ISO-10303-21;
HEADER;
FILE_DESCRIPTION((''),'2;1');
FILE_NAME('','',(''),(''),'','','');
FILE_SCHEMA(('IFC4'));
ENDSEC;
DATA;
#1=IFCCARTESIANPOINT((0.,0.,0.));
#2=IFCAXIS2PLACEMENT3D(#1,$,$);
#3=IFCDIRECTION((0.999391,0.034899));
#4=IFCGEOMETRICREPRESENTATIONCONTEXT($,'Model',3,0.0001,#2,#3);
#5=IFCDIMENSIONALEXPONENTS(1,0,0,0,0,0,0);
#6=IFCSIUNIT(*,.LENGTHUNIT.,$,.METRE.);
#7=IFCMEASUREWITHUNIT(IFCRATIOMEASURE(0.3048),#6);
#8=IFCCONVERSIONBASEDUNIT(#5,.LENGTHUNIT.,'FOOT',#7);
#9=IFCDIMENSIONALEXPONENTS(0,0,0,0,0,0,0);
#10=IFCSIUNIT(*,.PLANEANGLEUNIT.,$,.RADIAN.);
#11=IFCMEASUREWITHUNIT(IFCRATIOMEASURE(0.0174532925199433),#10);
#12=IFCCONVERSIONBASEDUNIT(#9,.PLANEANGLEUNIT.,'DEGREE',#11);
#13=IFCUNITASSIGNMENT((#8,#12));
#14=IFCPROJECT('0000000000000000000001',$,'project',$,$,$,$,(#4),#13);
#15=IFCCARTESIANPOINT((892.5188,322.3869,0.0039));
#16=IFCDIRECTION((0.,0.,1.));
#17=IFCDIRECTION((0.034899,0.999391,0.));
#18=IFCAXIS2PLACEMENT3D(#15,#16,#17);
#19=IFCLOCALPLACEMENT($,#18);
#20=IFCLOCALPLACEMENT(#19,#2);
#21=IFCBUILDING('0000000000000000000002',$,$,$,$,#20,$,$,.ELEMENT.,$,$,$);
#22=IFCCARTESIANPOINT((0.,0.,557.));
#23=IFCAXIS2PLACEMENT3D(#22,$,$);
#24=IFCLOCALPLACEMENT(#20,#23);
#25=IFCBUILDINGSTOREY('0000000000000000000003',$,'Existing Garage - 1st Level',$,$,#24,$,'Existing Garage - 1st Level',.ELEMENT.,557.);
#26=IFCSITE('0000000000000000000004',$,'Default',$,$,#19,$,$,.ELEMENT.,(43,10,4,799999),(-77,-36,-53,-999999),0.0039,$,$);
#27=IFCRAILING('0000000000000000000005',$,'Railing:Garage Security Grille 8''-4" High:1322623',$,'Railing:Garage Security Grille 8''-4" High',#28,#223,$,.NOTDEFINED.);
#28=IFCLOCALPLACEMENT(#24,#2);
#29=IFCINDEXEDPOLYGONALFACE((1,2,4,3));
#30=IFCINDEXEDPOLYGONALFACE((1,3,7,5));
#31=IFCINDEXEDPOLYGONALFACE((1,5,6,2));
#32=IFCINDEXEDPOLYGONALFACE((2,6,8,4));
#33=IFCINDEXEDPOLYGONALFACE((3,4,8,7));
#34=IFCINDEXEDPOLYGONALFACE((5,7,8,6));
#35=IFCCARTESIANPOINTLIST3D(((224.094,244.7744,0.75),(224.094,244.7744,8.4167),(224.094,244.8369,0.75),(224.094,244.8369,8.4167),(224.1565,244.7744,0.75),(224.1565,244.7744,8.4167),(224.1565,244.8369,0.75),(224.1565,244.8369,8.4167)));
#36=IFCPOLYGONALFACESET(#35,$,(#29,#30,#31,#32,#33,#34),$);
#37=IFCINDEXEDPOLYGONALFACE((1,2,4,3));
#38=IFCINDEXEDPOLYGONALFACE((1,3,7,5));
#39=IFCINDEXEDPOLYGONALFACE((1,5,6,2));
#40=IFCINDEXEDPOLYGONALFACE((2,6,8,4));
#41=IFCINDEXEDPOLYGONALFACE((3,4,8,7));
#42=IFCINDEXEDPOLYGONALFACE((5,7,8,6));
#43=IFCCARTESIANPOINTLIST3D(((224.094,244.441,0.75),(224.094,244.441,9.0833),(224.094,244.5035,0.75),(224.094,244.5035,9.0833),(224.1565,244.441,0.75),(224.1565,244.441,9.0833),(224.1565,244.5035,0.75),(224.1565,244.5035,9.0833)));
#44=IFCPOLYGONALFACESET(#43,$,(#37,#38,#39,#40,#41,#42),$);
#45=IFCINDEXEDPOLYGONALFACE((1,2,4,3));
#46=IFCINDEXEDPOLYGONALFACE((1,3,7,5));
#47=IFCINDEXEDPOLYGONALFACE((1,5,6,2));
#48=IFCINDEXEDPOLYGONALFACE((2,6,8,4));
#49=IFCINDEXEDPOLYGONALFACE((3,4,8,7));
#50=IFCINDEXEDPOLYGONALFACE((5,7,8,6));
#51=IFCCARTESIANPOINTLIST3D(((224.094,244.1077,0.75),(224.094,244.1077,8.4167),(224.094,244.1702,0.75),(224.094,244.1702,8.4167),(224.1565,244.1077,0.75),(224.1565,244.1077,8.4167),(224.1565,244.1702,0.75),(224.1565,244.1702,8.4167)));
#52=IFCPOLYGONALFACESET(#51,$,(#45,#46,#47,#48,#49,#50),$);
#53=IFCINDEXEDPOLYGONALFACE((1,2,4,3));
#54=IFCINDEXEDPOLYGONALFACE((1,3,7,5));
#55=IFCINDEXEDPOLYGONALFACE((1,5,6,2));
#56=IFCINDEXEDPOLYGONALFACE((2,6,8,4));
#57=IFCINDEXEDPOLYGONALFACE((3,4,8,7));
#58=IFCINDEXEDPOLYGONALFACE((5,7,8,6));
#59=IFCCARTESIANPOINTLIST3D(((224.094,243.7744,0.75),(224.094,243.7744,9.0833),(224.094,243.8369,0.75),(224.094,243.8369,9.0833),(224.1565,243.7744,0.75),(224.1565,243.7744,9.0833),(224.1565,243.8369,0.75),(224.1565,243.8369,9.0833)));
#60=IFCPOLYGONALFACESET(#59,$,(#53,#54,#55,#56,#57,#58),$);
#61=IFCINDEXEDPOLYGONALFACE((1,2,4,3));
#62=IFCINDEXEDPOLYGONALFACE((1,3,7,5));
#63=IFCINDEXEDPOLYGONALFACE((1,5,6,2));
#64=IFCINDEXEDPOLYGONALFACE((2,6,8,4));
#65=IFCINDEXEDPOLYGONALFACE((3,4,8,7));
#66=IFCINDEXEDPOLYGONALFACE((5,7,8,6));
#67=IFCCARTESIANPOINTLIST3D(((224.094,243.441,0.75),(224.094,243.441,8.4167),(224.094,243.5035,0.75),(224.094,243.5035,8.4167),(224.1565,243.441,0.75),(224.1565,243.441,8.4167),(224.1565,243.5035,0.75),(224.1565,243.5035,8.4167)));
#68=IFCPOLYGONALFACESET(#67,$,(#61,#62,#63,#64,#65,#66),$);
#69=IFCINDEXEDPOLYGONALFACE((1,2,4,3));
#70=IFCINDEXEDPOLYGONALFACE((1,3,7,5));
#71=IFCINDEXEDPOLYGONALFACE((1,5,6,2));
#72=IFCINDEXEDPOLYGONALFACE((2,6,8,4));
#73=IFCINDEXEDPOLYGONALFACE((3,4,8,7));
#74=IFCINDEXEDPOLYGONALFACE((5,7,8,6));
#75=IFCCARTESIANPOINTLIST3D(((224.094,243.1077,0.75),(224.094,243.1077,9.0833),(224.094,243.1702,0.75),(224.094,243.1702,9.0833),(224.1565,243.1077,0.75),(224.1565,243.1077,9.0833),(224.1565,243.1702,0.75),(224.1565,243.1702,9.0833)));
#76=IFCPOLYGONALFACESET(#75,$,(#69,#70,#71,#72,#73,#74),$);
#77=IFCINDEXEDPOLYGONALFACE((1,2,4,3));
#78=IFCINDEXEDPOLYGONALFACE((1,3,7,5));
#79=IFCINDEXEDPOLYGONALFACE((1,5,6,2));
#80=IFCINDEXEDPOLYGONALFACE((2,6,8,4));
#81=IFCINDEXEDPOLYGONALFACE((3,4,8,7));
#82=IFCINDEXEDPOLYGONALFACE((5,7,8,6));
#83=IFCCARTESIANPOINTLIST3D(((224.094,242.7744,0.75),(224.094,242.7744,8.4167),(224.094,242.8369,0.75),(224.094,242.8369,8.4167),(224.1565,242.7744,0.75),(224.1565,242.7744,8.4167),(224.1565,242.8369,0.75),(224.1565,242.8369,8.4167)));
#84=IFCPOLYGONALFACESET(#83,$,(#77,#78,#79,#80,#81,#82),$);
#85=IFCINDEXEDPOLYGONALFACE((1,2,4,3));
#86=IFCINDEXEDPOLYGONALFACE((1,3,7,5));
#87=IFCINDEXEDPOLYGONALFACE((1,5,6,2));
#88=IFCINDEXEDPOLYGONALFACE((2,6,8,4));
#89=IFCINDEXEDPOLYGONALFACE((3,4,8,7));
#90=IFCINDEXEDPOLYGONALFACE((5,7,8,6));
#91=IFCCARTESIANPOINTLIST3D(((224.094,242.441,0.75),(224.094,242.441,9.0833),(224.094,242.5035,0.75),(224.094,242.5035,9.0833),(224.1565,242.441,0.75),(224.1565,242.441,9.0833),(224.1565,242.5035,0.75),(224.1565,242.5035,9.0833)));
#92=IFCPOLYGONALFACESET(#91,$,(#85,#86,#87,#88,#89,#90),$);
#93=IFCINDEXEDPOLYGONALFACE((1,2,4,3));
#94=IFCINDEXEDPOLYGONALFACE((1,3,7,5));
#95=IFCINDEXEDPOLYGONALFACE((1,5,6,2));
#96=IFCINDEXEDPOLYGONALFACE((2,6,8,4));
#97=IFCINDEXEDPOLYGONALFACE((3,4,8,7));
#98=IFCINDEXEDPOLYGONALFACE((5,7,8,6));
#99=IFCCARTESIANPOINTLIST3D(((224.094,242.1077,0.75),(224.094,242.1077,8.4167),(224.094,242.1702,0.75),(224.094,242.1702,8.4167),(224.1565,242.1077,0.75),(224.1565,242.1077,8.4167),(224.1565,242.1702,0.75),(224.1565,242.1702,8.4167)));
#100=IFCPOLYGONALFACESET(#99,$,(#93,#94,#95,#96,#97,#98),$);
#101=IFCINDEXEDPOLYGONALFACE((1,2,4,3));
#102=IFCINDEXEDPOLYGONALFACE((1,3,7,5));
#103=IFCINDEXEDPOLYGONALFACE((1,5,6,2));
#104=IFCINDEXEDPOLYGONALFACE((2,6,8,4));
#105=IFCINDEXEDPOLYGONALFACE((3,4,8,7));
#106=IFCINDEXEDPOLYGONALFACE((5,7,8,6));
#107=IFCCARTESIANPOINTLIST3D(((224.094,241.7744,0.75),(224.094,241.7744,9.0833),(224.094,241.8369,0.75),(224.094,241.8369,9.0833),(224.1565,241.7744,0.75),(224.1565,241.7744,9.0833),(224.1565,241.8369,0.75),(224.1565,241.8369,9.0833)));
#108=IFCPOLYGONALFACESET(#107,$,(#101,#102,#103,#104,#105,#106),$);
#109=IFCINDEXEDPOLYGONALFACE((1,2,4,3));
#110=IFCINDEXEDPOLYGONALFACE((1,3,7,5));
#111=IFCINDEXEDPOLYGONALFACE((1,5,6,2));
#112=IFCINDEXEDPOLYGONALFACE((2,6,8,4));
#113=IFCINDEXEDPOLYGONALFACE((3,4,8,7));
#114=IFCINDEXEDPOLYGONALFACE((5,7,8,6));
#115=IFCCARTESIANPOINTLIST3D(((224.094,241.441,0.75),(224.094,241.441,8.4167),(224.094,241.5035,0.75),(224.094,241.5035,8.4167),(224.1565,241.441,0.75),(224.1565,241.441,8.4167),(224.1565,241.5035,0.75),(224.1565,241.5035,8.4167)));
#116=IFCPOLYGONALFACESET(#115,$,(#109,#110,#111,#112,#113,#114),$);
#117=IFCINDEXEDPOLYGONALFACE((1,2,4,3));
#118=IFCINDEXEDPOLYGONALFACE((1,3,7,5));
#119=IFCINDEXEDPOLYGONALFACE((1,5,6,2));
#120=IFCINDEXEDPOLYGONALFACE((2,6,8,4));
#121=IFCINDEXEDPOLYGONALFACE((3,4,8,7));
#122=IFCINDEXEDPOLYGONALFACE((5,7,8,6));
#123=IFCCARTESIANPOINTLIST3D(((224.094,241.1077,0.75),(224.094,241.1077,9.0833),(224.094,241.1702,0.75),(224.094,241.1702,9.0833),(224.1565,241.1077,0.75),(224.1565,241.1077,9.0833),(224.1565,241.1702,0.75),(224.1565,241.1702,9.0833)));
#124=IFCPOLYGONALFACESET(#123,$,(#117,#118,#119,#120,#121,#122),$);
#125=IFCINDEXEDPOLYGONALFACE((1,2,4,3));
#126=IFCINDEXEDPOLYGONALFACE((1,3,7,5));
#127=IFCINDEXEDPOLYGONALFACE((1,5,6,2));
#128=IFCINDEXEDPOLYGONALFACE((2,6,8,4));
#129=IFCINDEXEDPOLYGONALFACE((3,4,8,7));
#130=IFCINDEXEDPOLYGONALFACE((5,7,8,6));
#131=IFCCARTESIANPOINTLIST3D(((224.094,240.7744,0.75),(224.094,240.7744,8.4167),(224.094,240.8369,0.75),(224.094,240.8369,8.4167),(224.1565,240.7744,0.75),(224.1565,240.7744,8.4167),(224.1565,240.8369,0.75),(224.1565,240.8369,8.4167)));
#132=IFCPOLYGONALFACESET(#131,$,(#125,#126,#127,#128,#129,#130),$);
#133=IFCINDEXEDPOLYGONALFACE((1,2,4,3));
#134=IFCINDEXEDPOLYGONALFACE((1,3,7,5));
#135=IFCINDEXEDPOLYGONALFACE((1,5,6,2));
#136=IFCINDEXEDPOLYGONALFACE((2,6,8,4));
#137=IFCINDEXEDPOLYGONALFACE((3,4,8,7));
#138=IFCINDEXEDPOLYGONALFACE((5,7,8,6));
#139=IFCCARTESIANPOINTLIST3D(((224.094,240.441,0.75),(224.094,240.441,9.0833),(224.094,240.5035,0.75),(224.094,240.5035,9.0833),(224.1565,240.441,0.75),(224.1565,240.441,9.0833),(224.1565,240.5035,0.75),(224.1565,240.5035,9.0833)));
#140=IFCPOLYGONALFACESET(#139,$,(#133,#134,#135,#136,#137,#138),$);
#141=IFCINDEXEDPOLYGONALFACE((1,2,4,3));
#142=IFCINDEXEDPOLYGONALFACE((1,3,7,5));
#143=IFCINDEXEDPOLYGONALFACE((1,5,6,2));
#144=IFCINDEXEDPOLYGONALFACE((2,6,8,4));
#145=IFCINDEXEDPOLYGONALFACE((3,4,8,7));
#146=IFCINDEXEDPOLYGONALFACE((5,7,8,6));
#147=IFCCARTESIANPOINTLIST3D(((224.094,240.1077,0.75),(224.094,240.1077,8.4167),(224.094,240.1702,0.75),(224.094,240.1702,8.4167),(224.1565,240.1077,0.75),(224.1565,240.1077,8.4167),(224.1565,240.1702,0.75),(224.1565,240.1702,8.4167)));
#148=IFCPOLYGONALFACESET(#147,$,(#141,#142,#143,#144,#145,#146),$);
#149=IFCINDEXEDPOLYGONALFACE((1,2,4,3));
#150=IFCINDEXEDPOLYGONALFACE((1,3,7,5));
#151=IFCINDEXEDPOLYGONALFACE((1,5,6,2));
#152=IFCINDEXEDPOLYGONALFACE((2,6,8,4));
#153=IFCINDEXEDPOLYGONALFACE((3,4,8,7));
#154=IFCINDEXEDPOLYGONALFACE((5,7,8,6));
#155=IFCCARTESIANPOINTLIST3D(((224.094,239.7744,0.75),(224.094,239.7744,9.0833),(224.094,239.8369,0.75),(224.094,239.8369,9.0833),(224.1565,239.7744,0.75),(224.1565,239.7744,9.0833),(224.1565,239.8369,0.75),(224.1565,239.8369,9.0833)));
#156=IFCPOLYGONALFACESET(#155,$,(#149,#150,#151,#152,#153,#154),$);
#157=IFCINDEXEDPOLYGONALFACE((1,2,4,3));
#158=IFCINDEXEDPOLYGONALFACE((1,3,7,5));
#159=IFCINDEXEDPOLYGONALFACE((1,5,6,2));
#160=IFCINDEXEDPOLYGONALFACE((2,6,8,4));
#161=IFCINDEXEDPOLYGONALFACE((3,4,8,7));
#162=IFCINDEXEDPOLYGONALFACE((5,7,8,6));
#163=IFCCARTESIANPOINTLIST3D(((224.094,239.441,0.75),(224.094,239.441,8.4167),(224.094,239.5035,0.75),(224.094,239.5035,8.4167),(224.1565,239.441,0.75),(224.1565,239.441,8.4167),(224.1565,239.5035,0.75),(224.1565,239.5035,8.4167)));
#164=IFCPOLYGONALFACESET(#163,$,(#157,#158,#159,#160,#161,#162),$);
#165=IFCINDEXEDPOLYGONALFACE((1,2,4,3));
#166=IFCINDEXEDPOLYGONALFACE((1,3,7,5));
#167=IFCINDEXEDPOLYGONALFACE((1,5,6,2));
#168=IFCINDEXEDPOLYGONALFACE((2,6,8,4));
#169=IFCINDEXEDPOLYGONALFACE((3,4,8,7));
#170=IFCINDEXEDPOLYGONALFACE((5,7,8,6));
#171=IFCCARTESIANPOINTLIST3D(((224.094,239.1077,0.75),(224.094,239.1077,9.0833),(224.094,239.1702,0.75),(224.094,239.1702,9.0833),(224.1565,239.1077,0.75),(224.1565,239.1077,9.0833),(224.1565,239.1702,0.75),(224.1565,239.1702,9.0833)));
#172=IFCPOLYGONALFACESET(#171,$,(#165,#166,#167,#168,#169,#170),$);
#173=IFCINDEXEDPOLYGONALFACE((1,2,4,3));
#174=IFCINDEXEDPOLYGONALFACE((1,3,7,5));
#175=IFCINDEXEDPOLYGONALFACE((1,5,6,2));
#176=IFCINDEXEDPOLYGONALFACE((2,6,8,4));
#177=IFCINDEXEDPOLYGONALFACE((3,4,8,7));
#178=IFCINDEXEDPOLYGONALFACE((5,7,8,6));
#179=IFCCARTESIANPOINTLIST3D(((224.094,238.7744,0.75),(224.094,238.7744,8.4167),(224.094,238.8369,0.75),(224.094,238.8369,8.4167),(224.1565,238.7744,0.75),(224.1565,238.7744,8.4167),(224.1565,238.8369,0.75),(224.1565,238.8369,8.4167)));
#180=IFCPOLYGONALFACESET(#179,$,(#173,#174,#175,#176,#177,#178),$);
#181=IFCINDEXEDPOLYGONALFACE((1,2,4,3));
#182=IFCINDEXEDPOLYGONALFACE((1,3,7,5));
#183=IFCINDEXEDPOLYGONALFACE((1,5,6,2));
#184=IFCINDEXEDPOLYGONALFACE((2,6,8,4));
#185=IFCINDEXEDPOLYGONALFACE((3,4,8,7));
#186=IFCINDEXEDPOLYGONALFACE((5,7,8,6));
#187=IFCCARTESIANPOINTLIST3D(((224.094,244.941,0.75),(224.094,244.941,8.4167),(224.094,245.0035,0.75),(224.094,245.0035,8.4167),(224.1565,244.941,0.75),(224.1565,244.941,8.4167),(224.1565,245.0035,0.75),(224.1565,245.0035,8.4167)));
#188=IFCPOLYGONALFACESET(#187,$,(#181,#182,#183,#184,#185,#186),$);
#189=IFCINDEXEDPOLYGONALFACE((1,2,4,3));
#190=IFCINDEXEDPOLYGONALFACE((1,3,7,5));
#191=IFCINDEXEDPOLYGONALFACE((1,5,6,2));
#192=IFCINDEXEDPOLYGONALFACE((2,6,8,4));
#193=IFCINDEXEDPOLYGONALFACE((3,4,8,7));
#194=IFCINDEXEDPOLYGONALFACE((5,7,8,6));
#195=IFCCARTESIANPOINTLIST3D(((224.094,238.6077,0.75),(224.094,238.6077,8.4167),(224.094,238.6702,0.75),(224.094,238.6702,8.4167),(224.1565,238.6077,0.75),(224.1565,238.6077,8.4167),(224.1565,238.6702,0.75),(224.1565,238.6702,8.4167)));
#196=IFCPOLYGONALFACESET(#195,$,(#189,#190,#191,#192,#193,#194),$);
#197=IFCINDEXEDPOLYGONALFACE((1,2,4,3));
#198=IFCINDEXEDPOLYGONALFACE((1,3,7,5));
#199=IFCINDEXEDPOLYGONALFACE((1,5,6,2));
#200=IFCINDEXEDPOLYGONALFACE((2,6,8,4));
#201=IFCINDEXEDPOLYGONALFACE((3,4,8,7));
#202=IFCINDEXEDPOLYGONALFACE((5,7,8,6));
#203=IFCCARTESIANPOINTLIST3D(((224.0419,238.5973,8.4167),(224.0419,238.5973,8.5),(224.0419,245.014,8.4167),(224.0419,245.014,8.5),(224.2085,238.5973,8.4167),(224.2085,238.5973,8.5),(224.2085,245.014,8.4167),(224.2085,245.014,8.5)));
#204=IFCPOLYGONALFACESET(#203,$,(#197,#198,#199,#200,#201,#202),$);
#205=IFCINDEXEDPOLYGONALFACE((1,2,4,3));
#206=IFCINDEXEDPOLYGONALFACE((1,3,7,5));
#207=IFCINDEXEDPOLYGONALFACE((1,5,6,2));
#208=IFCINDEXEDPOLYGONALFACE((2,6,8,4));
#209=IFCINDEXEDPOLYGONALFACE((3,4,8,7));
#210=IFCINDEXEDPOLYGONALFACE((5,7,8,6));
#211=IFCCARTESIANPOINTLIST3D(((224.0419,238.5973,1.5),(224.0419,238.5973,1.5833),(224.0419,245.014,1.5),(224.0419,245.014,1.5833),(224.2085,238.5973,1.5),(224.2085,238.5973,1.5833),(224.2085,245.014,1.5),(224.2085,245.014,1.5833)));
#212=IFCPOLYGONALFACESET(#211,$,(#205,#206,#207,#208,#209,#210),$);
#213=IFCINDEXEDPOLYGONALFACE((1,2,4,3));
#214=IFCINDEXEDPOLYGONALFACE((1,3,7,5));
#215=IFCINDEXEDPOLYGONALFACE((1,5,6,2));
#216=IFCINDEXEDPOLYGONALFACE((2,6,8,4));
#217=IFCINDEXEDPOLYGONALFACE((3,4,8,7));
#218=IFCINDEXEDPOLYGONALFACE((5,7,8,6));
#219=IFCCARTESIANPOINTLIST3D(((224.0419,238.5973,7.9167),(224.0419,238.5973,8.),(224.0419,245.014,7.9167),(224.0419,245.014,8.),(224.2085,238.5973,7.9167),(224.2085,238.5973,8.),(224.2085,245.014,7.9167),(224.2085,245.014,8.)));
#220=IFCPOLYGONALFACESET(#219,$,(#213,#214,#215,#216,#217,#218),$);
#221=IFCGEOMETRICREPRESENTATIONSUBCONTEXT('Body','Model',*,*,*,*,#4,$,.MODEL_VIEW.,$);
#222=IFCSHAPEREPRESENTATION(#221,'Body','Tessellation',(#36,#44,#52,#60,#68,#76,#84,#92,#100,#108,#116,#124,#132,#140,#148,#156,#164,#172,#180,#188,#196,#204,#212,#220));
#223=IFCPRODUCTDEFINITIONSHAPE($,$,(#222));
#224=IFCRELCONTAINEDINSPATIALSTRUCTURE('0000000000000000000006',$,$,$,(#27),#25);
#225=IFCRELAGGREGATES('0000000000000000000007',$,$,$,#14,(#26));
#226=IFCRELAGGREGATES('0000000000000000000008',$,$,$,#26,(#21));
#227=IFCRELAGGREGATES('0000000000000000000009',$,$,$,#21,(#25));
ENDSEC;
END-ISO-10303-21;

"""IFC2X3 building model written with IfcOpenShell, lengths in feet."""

from ifc_helpers import new_model, entity, si_unit, converted_unit, direction, frame, frame_2d, origin, origin_2d_with_axis, place, context, subcontext, project, spatial, rectangle, extrude, element, save


model = new_model("IFC2X3")

# Units and contexts
model_context = context("Model", 3, precision=0.0001, world=origin(), true_north=direction((0.999391, 0.034899)))
body_context = subcontext(model_context, "Body", "Model", "MODEL_VIEW")
ifc_project = project(units=[converted_unit("LENGTHUNIT", "FOOT", entity("IfcRatioMeasure", 0.3048), si_unit("LENGTHUNIT", "METRE"), dimensions=[1, 0, 0, 0, 0, 0, 0]), converted_unit("PLANEANGLEUNIT", "DEGREE", entity("IfcRatioMeasure", 0.0174532925199433), si_unit("PLANEANGLEUNIT", "RADIAN"), dimensions=[0, 0, 0, 0, 0, 0, 0])], contexts=[model_context])

# Site, building, storey
site_placement = place(None, frame((892.5188, 322.3869, 0.0039), z_axis=(0.0, 0.0, 1.0), x_axis=(0.034899, 0.999391, 0.0)))
site = spatial("IfcSite", under=ifc_project, at=site_placement, Name="Default", CompositionType="ELEMENT", RefLatitude=(43, 10, 4, 799999), RefLongitude=(-77, -36, -53, -999999), RefElevation=0.0039)
building_placement = place(site_placement, origin())
building = spatial("IfcBuilding", under=site, at=building_placement, CompositionType="ELEMENT")
storey_placement = place(building_placement, frame((0.0, 0.0, 557.0)))
storey = spatial("IfcBuildingStorey", under=building, at=storey_placement, Name="Existing Garage - 1st Level", LongName="Existing Garage - 1st Level", CompositionType="ELEMENT", Elevation=557.0)

# Railing
railing_1_placement = place(storey_placement, origin())
element("IfcRailing", 1, at=railing_1_placement, inside=storey, Name="Railing:Garage Security Grille 8'-4\" High:1322623", ObjectType="Railing:Garage Security Grille 8'-4\" High", PredefinedType="NOTDEFINED", context=body_context, shape_type="SweptSolid", body=[
    extrude(rectangle(XDim=0.0625, YDim=0.0625, at=origin_2d_with_axis()), frame((224.1252, 244.8056, 0.75), z_axis=(0.0, 0.0, 1.0), x_axis=(0.0, 1.0, 0.0)), (0.0, 0.0, 1.0), 7.6667),
    extrude(rectangle(XDim=0.0625, YDim=0.0625, at=origin_2d_with_axis()), frame((224.1252, 244.4723, 0.75), z_axis=(0.0, 0.0, 1.0), x_axis=(0.0, 1.0, 0.0)), (0.0, 0.0, 1.0), 8.3333),
    extrude(rectangle(XDim=0.0625, YDim=0.0625, at=origin_2d_with_axis()), frame((224.1252, 244.139, 0.75), z_axis=(0.0, 0.0, 1.0), x_axis=(0.0, 1.0, 0.0)), (0.0, 0.0, 1.0), 7.6667),
    extrude(rectangle(XDim=0.0625, YDim=0.0625, at=origin_2d_with_axis()), frame((224.1252, 243.8056, 0.75), z_axis=(0.0, 0.0, 1.0), x_axis=(0.0, 1.0, 0.0)), (0.0, 0.0, 1.0), 8.3333),
    extrude(rectangle(XDim=0.0625, YDim=0.0625, at=origin_2d_with_axis()), frame((224.1252, 243.4723, 0.75), z_axis=(0.0, 0.0, 1.0), x_axis=(0.0, 1.0, 0.0)), (0.0, 0.0, 1.0), 7.6667),
    extrude(rectangle(XDim=0.0625, YDim=0.0625, at=origin_2d_with_axis()), frame((224.1252, 243.139, 0.75), z_axis=(0.0, 0.0, 1.0), x_axis=(0.0, 1.0, 0.0)), (0.0, 0.0, 1.0), 8.3333),
    extrude(rectangle(XDim=0.0625, YDim=0.0625, at=origin_2d_with_axis()), frame((224.1252, 242.8056, 0.75), z_axis=(0.0, 0.0, 1.0), x_axis=(0.0, 1.0, 0.0)), (0.0, 0.0, 1.0), 7.6667),
    extrude(rectangle(XDim=0.0625, YDim=0.0625, at=origin_2d_with_axis()), frame((224.1252, 242.4723, 0.75), z_axis=(0.0, 0.0, 1.0), x_axis=(0.0, 1.0, 0.0)), (0.0, 0.0, 1.0), 8.3333),
    extrude(rectangle(XDim=0.0625, YDim=0.0625, at=origin_2d_with_axis()), frame((224.1252, 242.139, 0.75), z_axis=(0.0, 0.0, 1.0), x_axis=(0.0, 1.0, 0.0)), (0.0, 0.0, 1.0), 7.6667),
    extrude(rectangle(XDim=0.0625, YDim=0.0625, at=origin_2d_with_axis()), frame((224.1252, 241.8056, 0.75), z_axis=(0.0, 0.0, 1.0), x_axis=(0.0, 1.0, 0.0)), (0.0, 0.0, 1.0), 8.3333),
    extrude(rectangle(XDim=0.0625, YDim=0.0625, at=origin_2d_with_axis()), frame((224.1252, 241.4723, 0.75), z_axis=(0.0, 0.0, 1.0), x_axis=(0.0, 1.0, 0.0)), (0.0, 0.0, 1.0), 7.6667),
    extrude(rectangle(XDim=0.0625, YDim=0.0625, at=origin_2d_with_axis()), frame((224.1252, 241.139, 0.75), z_axis=(0.0, 0.0, 1.0), x_axis=(0.0, 1.0, 0.0)), (0.0, 0.0, 1.0), 8.3333),
    extrude(rectangle(XDim=0.0625, YDim=0.0625, at=origin_2d_with_axis()), frame((224.1252, 240.8056, 0.75), z_axis=(0.0, 0.0, 1.0), x_axis=(0.0, 1.0, 0.0)), (0.0, 0.0, 1.0), 7.6667),
    extrude(rectangle(XDim=0.0625, YDim=0.0625, at=origin_2d_with_axis()), frame((224.1252, 240.4723, 0.75), z_axis=(0.0, 0.0, 1.0), x_axis=(0.0, 1.0, 0.0)), (0.0, 0.0, 1.0), 8.3333),
    extrude(rectangle(XDim=0.0625, YDim=0.0625, at=origin_2d_with_axis()), frame((224.1252, 240.139, 0.75), z_axis=(0.0, 0.0, 1.0), x_axis=(0.0, 1.0, 0.0)), (0.0, 0.0, 1.0), 7.6667),
    extrude(rectangle(XDim=0.0625, YDim=0.0625, at=origin_2d_with_axis()), frame((224.1252, 239.8056, 0.75), z_axis=(0.0, 0.0, 1.0), x_axis=(0.0, 1.0, 0.0)), (0.0, 0.0, 1.0), 8.3333),
    extrude(rectangle(XDim=0.0625, YDim=0.0625, at=origin_2d_with_axis()), frame((224.1252, 239.4723, 0.75), z_axis=(0.0, 0.0, 1.0), x_axis=(0.0, 1.0, 0.0)), (0.0, 0.0, 1.0), 7.6667),
    extrude(rectangle(XDim=0.0625, YDim=0.0625, at=origin_2d_with_axis()), frame((224.1252, 239.139, 0.75), z_axis=(0.0, 0.0, 1.0), x_axis=(0.0, 1.0, 0.0)), (0.0, 0.0, 1.0), 8.3333),
    extrude(rectangle(XDim=0.0625, YDim=0.0625, at=origin_2d_with_axis()), frame((224.1252, 238.8056, 0.75), z_axis=(0.0, 0.0, 1.0), x_axis=(0.0, 1.0, 0.0)), (0.0, 0.0, 1.0), 7.6667),
    extrude(rectangle(XDim=0.0625, YDim=0.0625, at=origin_2d_with_axis()), frame((224.1252, 244.9723, 0.75), z_axis=(0.0, 0.0, 1.0), x_axis=(0.0, 1.0, 0.0)), (0.0, 0.0, 1.0), 7.6667),
    extrude(rectangle(XDim=0.0625, YDim=0.0625, at=origin_2d_with_axis()), frame((224.1252, 238.639, 0.75), z_axis=(0.0, 0.0, 1.0), x_axis=(0.0, 1.0, 0.0)), (0.0, 0.0, 1.0), 7.6667),
    extrude(rectangle(XDim=6.4167, YDim=0.1667, at=frame_2d((0.0, 0.0), x_axis=(1.0, 0.0))), frame((224.1252, 241.8056, 8.4167), z_axis=(0.0, 0.0, 1.0), x_axis=(0.0, 1.0, 0.0)), (0.0, 0.0, 1.0), 0.0833),
    extrude(rectangle(XDim=6.4167, YDim=0.1667, at=frame_2d((0.0, 0.0), x_axis=(1.0, 0.0))), frame((224.1252, 241.8056, 1.5), z_axis=(0.0, 0.0, 1.0), x_axis=(0.0, 1.0, 0.0)), (0.0, 0.0, 1.0), 0.0833),
    extrude(rectangle(XDim=6.4167, YDim=0.1667, at=frame_2d((0.0, 0.0), x_axis=(1.0, 0.0))), frame((224.1252, 241.8056, 7.9167), z_axis=(0.0, 0.0, 1.0), x_axis=(0.0, 1.0, 0.0)), (0.0, 0.0, 1.0), 0.0833),
])

save(model, "model.ifc")
